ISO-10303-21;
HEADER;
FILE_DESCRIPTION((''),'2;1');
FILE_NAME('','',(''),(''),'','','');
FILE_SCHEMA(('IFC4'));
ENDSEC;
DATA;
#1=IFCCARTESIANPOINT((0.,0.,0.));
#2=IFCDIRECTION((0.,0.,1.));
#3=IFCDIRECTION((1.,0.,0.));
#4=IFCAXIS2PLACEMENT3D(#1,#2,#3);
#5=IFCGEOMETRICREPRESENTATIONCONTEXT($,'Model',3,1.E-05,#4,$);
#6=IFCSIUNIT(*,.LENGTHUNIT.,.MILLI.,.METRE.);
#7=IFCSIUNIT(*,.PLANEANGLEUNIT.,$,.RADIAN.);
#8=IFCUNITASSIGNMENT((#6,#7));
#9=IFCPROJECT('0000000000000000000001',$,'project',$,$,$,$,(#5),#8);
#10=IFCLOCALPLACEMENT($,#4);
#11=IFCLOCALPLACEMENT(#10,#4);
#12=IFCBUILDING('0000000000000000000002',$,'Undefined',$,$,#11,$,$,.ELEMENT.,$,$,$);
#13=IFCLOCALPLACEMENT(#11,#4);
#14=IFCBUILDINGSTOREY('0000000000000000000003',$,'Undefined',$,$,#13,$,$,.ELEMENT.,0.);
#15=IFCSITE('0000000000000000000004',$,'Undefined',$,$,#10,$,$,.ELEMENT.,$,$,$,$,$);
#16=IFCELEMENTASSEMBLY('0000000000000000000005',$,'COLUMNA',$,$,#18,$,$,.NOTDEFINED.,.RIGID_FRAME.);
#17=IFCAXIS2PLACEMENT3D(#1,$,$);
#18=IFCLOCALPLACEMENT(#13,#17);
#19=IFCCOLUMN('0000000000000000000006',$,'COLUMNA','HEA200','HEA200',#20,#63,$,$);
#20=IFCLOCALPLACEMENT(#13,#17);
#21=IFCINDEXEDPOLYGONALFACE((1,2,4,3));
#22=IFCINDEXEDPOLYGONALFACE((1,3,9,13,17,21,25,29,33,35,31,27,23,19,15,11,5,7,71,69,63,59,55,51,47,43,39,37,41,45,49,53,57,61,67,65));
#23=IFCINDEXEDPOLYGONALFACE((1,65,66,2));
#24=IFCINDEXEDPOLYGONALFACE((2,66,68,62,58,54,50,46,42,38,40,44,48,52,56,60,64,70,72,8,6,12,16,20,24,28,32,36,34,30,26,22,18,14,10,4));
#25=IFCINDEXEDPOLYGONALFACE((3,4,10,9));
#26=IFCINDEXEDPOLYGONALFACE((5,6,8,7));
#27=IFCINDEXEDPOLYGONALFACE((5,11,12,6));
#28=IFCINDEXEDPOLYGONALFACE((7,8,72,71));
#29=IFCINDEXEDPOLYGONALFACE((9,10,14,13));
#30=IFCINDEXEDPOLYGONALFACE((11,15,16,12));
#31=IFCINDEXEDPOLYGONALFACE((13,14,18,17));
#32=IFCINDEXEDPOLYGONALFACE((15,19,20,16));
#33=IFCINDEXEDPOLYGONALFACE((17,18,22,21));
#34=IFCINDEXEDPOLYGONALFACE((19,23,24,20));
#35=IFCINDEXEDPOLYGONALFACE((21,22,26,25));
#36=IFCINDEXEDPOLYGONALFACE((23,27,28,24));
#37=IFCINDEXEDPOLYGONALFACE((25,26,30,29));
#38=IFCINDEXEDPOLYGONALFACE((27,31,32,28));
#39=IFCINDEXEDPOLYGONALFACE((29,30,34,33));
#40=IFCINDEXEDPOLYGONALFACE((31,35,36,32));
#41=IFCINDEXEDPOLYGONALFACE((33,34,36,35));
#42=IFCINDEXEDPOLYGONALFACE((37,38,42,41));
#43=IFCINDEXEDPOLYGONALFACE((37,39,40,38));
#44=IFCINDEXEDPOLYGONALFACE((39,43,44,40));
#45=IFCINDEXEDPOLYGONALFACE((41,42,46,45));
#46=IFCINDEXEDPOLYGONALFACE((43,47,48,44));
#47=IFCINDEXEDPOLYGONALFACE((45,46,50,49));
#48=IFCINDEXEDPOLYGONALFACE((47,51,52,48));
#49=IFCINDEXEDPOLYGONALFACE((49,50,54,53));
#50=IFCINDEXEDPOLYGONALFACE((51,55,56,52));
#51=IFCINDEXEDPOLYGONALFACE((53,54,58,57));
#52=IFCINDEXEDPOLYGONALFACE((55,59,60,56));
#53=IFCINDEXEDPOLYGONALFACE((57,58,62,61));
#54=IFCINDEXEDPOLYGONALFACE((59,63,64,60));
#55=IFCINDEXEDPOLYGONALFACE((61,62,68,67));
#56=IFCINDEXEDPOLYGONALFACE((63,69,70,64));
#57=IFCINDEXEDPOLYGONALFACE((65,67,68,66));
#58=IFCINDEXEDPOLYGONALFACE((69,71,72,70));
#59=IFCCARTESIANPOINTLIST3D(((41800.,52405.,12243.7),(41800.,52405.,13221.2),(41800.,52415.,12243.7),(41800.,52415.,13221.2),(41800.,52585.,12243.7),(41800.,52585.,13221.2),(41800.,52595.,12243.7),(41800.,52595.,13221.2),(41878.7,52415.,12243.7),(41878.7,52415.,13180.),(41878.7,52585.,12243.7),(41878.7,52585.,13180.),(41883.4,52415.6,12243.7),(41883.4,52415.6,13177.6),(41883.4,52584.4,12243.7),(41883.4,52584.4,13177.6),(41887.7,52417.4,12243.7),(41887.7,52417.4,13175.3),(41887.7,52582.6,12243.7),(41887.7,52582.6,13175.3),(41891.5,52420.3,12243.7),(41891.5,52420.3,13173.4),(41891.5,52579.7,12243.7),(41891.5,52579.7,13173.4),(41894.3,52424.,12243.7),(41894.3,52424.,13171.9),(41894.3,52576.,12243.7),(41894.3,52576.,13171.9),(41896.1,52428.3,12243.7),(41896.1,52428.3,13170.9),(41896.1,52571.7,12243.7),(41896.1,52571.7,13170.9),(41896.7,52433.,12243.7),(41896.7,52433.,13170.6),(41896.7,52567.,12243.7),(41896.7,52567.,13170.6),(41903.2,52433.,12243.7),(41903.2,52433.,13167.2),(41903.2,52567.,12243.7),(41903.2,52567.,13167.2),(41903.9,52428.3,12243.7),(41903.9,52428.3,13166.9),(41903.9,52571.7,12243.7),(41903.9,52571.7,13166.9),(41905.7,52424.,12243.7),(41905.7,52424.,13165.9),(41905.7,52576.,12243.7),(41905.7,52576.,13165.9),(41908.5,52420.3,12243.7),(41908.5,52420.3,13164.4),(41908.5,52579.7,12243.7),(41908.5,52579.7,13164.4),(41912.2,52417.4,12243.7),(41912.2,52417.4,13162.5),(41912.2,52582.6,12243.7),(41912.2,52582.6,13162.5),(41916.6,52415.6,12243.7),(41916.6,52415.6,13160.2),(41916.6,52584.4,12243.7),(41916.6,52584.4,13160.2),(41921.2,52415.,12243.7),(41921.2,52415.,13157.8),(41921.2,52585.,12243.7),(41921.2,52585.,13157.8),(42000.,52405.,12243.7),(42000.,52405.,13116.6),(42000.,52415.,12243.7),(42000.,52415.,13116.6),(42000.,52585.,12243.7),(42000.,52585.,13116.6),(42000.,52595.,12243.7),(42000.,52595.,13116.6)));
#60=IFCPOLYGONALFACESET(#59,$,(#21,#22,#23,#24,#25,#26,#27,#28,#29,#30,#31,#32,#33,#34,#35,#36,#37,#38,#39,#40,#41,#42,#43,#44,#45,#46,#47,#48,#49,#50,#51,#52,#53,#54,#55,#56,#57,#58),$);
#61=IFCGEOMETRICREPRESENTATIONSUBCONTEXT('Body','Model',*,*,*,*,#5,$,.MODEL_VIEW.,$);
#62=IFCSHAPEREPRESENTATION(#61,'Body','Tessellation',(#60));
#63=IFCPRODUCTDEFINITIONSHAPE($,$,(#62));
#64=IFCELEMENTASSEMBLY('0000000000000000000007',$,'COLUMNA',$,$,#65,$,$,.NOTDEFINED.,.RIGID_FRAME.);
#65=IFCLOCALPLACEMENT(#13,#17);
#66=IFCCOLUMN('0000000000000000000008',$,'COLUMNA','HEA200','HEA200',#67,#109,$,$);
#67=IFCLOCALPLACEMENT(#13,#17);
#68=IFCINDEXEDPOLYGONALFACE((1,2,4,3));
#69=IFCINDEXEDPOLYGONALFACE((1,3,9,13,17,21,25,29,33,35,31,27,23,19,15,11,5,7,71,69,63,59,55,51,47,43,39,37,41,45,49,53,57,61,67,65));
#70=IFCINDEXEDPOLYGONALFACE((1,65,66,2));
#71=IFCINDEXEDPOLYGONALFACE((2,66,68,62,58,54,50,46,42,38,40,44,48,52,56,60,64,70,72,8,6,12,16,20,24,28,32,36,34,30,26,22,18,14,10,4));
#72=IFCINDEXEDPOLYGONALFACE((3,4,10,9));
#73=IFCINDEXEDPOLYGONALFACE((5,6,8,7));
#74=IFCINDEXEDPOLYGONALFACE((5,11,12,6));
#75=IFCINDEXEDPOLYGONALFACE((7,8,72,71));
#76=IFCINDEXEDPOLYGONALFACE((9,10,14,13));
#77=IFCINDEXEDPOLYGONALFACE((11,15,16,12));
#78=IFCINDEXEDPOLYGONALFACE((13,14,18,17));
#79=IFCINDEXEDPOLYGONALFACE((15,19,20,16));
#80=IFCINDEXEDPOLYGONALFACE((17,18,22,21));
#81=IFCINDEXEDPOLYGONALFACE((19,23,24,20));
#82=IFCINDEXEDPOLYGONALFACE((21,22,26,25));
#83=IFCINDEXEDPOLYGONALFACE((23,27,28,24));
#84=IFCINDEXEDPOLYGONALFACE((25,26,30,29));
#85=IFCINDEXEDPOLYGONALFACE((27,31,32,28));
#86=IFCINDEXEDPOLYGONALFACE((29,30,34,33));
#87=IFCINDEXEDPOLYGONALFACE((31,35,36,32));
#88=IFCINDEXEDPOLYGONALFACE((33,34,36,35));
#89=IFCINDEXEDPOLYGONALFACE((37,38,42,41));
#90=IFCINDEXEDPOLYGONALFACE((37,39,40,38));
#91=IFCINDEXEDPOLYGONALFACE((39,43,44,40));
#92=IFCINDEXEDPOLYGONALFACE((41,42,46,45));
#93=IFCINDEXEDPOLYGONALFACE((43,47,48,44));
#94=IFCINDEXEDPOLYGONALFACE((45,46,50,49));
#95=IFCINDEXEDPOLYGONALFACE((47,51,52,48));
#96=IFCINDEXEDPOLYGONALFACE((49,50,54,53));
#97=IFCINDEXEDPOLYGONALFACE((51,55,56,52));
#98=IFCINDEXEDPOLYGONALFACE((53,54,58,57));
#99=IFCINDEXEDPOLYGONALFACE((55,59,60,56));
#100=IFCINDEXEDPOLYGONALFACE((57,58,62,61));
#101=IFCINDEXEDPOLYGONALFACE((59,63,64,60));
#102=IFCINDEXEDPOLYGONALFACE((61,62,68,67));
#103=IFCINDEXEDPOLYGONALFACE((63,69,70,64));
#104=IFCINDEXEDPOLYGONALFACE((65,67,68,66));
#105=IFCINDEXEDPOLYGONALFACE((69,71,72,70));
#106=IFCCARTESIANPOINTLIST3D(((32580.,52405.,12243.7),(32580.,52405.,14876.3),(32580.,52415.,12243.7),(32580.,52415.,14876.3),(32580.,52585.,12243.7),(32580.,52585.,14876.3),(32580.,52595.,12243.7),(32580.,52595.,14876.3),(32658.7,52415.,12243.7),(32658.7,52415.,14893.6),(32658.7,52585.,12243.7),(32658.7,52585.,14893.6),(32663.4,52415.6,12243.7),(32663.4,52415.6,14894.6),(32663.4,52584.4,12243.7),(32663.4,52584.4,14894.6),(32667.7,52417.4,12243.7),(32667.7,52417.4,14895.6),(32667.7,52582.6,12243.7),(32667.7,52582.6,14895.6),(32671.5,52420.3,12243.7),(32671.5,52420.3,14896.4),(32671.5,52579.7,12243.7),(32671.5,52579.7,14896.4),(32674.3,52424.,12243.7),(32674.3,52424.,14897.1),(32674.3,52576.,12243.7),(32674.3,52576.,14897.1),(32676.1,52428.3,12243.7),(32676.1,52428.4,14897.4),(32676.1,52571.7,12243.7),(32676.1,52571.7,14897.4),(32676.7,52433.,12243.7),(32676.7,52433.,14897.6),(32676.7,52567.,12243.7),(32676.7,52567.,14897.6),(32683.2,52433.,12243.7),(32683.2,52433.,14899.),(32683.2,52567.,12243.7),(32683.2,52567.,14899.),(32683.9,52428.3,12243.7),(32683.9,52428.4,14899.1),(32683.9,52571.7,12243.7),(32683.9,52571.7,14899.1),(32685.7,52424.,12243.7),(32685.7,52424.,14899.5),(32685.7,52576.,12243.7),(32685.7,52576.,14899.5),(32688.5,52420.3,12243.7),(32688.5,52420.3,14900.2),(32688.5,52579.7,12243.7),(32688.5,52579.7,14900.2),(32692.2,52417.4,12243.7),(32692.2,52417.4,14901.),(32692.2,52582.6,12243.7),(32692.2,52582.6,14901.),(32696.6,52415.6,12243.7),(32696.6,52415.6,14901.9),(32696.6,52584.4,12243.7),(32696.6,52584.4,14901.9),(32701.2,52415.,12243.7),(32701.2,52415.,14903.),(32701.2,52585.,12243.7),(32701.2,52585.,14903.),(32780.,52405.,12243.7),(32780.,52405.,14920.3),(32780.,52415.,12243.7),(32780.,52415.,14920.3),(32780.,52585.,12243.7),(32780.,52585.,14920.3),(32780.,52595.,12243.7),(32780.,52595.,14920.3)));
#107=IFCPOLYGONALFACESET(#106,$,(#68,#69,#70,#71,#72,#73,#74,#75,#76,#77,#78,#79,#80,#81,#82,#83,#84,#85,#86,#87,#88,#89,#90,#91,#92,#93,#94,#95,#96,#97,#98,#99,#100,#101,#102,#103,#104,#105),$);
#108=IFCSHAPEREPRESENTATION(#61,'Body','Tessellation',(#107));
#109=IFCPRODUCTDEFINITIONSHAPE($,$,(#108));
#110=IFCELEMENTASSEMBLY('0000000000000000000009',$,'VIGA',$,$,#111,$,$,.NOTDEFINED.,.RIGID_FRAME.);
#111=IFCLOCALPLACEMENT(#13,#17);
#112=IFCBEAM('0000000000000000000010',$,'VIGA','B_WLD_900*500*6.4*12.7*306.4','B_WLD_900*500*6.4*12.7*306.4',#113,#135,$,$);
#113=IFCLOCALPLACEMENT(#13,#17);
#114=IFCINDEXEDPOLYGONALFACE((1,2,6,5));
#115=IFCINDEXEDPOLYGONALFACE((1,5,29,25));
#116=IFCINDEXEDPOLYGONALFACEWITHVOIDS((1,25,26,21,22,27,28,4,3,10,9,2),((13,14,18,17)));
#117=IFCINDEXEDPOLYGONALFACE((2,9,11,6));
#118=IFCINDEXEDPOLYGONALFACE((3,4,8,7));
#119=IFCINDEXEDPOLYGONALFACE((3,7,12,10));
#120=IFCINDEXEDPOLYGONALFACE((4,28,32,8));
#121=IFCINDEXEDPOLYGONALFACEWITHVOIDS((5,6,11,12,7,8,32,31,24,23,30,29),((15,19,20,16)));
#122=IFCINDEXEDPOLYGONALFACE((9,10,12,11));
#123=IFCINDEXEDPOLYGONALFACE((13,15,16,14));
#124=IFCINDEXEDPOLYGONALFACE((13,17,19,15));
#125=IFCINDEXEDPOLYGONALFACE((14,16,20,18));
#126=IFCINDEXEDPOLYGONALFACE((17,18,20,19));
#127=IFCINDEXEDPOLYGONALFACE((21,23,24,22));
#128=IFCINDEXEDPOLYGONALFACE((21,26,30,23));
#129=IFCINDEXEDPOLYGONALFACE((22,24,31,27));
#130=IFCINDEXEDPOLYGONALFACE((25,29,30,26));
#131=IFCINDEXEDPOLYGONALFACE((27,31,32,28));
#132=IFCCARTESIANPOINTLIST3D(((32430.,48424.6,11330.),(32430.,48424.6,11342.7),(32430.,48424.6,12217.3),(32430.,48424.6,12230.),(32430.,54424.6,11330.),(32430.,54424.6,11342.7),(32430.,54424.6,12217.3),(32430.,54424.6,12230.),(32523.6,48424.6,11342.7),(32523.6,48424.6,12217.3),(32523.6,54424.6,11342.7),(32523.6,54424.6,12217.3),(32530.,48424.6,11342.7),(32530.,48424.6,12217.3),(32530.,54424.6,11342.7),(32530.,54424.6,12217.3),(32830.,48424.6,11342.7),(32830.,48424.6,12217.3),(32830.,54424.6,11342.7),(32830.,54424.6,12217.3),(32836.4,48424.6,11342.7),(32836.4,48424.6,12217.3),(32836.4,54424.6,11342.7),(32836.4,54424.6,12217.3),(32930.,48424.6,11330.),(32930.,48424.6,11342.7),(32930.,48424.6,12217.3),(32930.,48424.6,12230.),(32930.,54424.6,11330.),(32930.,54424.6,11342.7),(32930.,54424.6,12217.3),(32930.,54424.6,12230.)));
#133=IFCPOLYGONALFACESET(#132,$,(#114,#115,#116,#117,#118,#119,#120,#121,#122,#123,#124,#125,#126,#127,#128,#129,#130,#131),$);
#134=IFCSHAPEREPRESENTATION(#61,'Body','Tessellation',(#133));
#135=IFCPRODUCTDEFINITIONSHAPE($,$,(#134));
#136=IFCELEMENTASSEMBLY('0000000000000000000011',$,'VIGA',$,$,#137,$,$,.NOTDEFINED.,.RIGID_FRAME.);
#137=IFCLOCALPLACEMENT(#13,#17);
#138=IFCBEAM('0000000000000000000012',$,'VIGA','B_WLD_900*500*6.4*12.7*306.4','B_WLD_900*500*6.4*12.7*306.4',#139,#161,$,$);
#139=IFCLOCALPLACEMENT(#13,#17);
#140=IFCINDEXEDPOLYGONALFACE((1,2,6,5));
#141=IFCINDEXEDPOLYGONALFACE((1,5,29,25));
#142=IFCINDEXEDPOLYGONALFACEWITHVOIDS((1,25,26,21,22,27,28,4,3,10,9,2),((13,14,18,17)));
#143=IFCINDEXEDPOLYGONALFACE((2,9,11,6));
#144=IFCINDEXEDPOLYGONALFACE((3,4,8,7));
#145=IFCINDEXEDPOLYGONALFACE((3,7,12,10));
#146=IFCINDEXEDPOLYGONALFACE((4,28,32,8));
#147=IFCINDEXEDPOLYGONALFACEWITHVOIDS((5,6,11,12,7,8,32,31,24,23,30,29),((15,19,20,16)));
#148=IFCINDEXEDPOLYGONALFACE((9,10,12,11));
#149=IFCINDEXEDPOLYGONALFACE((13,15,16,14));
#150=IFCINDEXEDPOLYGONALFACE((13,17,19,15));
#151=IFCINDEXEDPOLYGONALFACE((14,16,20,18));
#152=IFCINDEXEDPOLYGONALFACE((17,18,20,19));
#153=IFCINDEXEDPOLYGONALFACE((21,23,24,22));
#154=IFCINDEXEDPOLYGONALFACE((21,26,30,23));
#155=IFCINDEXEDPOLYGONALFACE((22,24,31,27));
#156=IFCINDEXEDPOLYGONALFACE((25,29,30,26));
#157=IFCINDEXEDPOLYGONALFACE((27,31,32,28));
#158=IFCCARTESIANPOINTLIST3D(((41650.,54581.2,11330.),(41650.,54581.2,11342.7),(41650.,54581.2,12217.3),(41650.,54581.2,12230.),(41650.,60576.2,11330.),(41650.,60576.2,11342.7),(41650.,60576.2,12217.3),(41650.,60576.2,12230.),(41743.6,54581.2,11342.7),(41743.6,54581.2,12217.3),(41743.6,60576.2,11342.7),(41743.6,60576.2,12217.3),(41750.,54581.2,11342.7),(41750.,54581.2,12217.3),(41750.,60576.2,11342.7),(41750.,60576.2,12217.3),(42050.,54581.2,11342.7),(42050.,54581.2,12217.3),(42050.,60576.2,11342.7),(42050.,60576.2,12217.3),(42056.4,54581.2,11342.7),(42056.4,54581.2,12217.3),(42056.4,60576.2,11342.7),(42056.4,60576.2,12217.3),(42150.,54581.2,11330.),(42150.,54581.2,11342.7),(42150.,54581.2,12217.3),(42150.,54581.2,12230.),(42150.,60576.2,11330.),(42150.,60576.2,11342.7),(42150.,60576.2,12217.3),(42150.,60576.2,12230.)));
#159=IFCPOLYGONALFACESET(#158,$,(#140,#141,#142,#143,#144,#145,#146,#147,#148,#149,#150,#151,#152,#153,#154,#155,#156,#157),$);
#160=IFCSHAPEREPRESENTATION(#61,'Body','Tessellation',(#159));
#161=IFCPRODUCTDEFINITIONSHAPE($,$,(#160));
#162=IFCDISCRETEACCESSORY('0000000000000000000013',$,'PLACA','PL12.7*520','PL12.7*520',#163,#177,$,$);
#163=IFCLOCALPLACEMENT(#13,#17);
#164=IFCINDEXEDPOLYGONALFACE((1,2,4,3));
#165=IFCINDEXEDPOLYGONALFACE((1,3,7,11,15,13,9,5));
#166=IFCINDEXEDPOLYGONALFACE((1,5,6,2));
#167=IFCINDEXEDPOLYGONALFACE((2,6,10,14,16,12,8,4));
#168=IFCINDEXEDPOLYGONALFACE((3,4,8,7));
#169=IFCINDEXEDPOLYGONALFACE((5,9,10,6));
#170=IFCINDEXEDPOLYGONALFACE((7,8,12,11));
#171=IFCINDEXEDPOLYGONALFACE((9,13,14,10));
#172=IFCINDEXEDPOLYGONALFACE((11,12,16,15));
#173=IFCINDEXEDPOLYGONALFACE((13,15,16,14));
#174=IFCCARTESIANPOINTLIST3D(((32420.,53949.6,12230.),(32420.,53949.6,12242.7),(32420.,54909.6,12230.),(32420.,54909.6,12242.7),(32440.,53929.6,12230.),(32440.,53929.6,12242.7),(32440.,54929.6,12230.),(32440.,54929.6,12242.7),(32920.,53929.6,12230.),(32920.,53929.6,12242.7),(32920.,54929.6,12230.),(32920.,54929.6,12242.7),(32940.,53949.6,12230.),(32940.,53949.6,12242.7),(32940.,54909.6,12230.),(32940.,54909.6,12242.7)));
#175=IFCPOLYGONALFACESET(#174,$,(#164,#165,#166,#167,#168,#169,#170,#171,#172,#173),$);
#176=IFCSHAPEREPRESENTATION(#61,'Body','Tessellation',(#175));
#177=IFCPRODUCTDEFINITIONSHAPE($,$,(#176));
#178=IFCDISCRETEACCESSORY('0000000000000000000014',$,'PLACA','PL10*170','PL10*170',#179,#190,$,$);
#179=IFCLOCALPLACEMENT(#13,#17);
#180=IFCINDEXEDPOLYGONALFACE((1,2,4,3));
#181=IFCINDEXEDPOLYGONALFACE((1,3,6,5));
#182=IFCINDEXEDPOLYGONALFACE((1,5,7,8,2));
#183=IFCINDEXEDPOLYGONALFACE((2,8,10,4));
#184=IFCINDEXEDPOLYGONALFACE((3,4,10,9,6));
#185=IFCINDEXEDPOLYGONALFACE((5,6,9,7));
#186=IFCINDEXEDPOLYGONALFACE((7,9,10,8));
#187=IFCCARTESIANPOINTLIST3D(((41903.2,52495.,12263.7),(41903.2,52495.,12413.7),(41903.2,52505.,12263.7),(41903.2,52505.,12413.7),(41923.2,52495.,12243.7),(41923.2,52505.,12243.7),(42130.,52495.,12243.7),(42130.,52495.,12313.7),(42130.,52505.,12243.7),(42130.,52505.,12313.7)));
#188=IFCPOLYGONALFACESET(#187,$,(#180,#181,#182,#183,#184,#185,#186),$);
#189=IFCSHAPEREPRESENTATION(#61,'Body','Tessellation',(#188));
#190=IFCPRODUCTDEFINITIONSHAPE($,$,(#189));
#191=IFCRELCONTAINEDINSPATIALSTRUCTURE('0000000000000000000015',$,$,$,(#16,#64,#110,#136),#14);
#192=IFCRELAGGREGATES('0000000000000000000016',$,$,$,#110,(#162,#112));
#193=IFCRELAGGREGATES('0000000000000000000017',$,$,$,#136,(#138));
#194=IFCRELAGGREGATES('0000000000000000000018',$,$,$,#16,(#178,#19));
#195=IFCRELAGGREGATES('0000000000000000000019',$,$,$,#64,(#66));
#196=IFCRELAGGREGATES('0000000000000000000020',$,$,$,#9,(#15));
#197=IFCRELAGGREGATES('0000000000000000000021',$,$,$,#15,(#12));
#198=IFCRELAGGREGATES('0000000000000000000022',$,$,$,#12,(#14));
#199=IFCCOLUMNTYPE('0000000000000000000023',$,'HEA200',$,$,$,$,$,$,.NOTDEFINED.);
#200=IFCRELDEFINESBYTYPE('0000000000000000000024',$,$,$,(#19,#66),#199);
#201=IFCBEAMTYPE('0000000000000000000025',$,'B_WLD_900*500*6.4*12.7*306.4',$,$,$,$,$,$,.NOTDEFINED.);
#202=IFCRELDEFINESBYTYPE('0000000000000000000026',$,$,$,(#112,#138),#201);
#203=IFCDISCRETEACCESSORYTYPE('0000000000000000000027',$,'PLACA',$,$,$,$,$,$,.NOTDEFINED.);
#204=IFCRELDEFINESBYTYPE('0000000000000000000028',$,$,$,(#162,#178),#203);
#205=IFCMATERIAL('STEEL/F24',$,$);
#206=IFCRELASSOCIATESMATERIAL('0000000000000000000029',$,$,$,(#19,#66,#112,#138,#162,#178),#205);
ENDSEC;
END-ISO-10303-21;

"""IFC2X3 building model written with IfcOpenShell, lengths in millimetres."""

from ifc_helpers import new_model, si_unit, frame, origin_with_axes, origin_2d_with_axis, place, context, subcontext, project, spatial, polyline, i_section, outline, extrude, clip, halfspace, material, type_object, element, aggregate, save


model = new_model("IFC2X3")

# Units and contexts
model_context = context("Model", 3, precision=1e-05, world=origin_with_axes())
body_context = subcontext(model_context, "Body", "Model", "MODEL_VIEW")
ifc_project = project(units=[si_unit("LENGTHUNIT", "METRE", prefix="MILLI"), si_unit("PLANEANGLEUNIT", "RADIAN")], contexts=[model_context])

# Site, building, storey
site_placement = place(None, origin_with_axes())
site = spatial("IfcSite", under=ifc_project, at=site_placement, Name="Undefined", CompositionType="ELEMENT")
building_placement = place(site_placement, origin_with_axes())
building = spatial("IfcBuilding", under=site, at=building_placement, Name="Undefined", CompositionType="ELEMENT")
storey_placement = place(building_placement, origin_with_axes())
storey = spatial("IfcBuildingStorey", under=building, at=storey_placement, Name="Undefined", CompositionType="ELEMENT", Elevation=0.0)

# Element assemblies, columns
assembly_1_placement = place(storey_placement, origin_with_axes())
assembly_1 = element("IfcElementAssembly", 1, at=assembly_1_placement, inside=storey, Name="COLUMNA", AssemblyPlace="NOTDEFINED", PredefinedType="RIGID_FRAME")
ifc_material_1 = material(Name="STEEL/F24")
column_type = type_object("IfcColumnType", Name="HEA200", PredefinedType="NOTDEFINED")
column_1_placement = place(assembly_1_placement, frame((41900.0, 52500.0, 12230.0), z_axis=(0.0, 0.0, 1.0), x_axis=(0.0, -1.0, 0.0)))
column_1 = element("IfcColumn", 2, at=column_1_placement, type_object=column_type, material=ifc_material_1, Name="COLUMNA", Description="HEA200", ObjectType="HEA200", context=body_context, shape_type="Clipping", body=[
    clip(clip(extrude(i_section(OverallWidth=200.0, OverallDepth=190.0, WebThickness=6.5, FlangeThickness=10.0, FilletRadius=18.0, at=origin_2d_with_axis()), frame((0.0, 0.0, 991.7), z_axis=(0.0, 0.0, -1.0), x_axis=(0.0, 1.0, 0.0)), (0.0, 0.0, 1.0), 1030.9), halfspace(frame((0.0, -100.0, 991.2), z_axis=(0.0, -0.463578, -0.886056), x_axis=(1.0, 0.0, 0.0)), True)), halfspace(frame((-95.0, 0.0, 13.7), z_axis=(0.0, 0.0, 1.0), x_axis=(0.0, 1.0, 0.0)), True)),
])
assembly_2_placement = place(storey_placement, origin_with_axes())
assembly_2 = element("IfcElementAssembly", 3, at=assembly_2_placement, inside=storey, Name="COLUMNA", AssemblyPlace="NOTDEFINED", PredefinedType="RIGID_FRAME")
column_2_placement = place(assembly_2_placement, frame((32680.0, 52500.0, 12230.0), z_axis=(0.0, 0.000004, 1.0), x_axis=(0.0, -1.0, 0.000004)))
column_2 = element("IfcColumn", 4, at=column_2_placement, type_object=column_type, material=ifc_material_1, Name="COLUMNA", Description="HEA200", ObjectType="HEA200", context=body_context, shape_type="Clipping", body=[
    clip(clip(extrude(i_section(OverallWidth=200.0, OverallDepth=190.0, WebThickness=6.5, FlangeThickness=10.0, FilletRadius=18.0, at=origin_2d_with_axis()), frame((0.0, 0.0, 2690.5), z_axis=(0.0, 0.0, -1.0), x_axis=(0.0, 1.0, 0.0)), (0.0, 0.0, 1.0), 2699.0), halfspace(frame((0.0, 100.0, 2690.3), z_axis=(-0.000003, 0.214887, -0.976639), x_axis=(-1.0, 0.0, 0.000003)), True)), halfspace(frame((-95.0, 0.0, 13.7), z_axis=(0.000004, 0.0, 1.0), x_axis=(0.0, 1.0, 0.0)), True)),
])

# Element assemblies, beams
assembly_3_placement = place(storey_placement, origin_with_axes())
assembly_3 = element("IfcElementAssembly", 5, at=assembly_3_placement, inside=storey, Name="VIGA", AssemblyPlace="NOTDEFINED", PredefinedType="RIGID_FRAME")
beam_type = type_object("IfcBeamType", Name="B_WLD_900*500*6.4*12.7*306.4", PredefinedType="NOTDEFINED")
beam_1_placement = place(assembly_3_placement, frame((32680.0, 48424.6, 11780.0), z_axis=(0.0, 0.0, 1.0), x_axis=(0.0, 1.0, 0.0)))
beam_1 = element("IfcBeam", 6, at=beam_1_placement, type_object=beam_type, material=ifc_material_1, Name="VIGA", Description="B_WLD_900*500*6.4*12.7*306.4", ObjectType="B_WLD_900*500*6.4*12.7*306.4", context=body_context, shape_type="SweptSolid", body=[
    extrude(outline(polyline([(-250.0, 437.3), (-250.0, 450.0), (250.0, 450.0), (250.0, 437.3), (156.4, 437.3), (156.4, -437.3), (250.0, -437.3), (250.0, -450.0), (-250.0, -450.0), (-250.0, -437.3), (-156.4, -437.3), (-156.4, 437.3), (-250.0, 437.3)]), holes=[polyline([(-150.0, -437.3), (150.0, -437.3), (150.0, 437.3), (-150.0, 437.3), (-150.0, -437.3)])]), frame((6000.0, 0.0, 0.0), z_axis=(-1.0, 0.0, 0.0), x_axis=(0.0, -1.0, 0.0)), (0.0, 0.0, 1.0), 6000.0),
])
assembly_4_placement = place(storey_placement, origin_with_axes())
assembly_4 = element("IfcElementAssembly", 7, at=assembly_4_placement, inside=storey, Name="VIGA", AssemblyPlace="NOTDEFINED", PredefinedType="RIGID_FRAME")
beam_2_placement = place(assembly_4_placement, frame((41900.0, 54576.2, 11780.0), z_axis=(0.0, 0.0, 1.0), x_axis=(0.0, 1.0, 0.0)))
beam_2 = element("IfcBeam", 8, at=beam_2_placement, type_object=beam_type, material=ifc_material_1, Name="VIGA", Description="B_WLD_900*500*6.4*12.7*306.4", ObjectType="B_WLD_900*500*6.4*12.7*306.4", context=body_context, shape_type="Clipping", body=[
    clip(extrude(outline(polyline([(-250.0, 437.3), (-250.0, 450.0), (250.0, 450.0), (250.0, 437.3), (156.4, 437.3), (156.4, -437.3), (250.0, -437.3), (250.0, -450.0), (-250.0, -450.0), (-250.0, -437.3), (-156.4, -437.3), (-156.4, 437.3), (-250.0, 437.3)]), holes=[polyline([(-150.0, -437.3), (150.0, -437.3), (150.0, 437.3), (-150.0, 437.3), (-150.0, -437.3)])]), frame((6000.0, 0.0, 0.0), z_axis=(-1.0, 0.0, 0.0), x_axis=(0.0, -1.0, 0.0)), (0.0, 0.0, 1.0), 6000.0), halfspace(frame((5.0, -175.0, 450.0), z_axis=(-1.0, -0.000001, 0.0), x_axis=(0.0, 0.0, -1.0)), False)),
])

# Discrete accessories
discrete_accessory_type_1 = type_object("IfcDiscreteAccessoryType", Name="PLACA")
discrete_accessory_1_placement = place(assembly_3_placement, frame((32940.0, 54929.6, 12236.3), z_axis=(0.0, 0.0, -1.0), x_axis=(0.0, -1.0, 0.0)))
discrete_accessory_1 = element("IfcDiscreteAccessory", 9, at=discrete_accessory_1_placement, type_object=discrete_accessory_type_1, material=ifc_material_1, Name="PLACA", Description="PL12.7*520", ObjectType="PL12.7*520", context=body_context, shape_type="SweptSolid", body=[
    extrude(outline(polyline([(0.0, 20.0), (20.0, 0.0), (980.0, 0.0), (1000.0, 20.0), (1000.0, 500.0), (980.0, 520.0), (20.0, 520.0), (0.0, 500.0), (0.0, 20.0)])), frame((0.0, 0.0, -6.3), z_axis=(0.0, 0.0, 1.0), x_axis=(1.0, 0.0, 0.0)), (0.0, 0.0, 1.0), 12.7),
])
discrete_accessory_2_placement = place(assembly_1_placement, frame((41903.2, 52500.0, 12243.7), z_axis=(0.0, 1.0, 0.0), x_axis=(0.0, 0.0, 1.0)))
discrete_accessory_2 = element("IfcDiscreteAccessory", 10, at=discrete_accessory_2_placement, type_object=discrete_accessory_type_1, material=ifc_material_1, Name="PLACA", Description="PL10*170", ObjectType="PL10*170", context=body_context, shape_type="SweptSolid", body=[
    extrude(outline(polyline([(0.0, 20.0), (20.0, 0.0), (170.0, 0.0), (70.0, 226.7), (0.0, 226.7), (0.0, 20.0)])), frame((0.0, 0.0, -5.0), z_axis=(0.0, 0.0, 1.0), x_axis=(1.0, 0.0, 0.0)), (0.0, 0.0, 1.0), 10.0),
])

aggregate(assembly_3, [discrete_accessory_1, beam_1])
aggregate(assembly_4, [beam_2])
aggregate(assembly_1, [discrete_accessory_2, column_1])
aggregate(assembly_2, [column_2])

save(model, "model.ifc")
